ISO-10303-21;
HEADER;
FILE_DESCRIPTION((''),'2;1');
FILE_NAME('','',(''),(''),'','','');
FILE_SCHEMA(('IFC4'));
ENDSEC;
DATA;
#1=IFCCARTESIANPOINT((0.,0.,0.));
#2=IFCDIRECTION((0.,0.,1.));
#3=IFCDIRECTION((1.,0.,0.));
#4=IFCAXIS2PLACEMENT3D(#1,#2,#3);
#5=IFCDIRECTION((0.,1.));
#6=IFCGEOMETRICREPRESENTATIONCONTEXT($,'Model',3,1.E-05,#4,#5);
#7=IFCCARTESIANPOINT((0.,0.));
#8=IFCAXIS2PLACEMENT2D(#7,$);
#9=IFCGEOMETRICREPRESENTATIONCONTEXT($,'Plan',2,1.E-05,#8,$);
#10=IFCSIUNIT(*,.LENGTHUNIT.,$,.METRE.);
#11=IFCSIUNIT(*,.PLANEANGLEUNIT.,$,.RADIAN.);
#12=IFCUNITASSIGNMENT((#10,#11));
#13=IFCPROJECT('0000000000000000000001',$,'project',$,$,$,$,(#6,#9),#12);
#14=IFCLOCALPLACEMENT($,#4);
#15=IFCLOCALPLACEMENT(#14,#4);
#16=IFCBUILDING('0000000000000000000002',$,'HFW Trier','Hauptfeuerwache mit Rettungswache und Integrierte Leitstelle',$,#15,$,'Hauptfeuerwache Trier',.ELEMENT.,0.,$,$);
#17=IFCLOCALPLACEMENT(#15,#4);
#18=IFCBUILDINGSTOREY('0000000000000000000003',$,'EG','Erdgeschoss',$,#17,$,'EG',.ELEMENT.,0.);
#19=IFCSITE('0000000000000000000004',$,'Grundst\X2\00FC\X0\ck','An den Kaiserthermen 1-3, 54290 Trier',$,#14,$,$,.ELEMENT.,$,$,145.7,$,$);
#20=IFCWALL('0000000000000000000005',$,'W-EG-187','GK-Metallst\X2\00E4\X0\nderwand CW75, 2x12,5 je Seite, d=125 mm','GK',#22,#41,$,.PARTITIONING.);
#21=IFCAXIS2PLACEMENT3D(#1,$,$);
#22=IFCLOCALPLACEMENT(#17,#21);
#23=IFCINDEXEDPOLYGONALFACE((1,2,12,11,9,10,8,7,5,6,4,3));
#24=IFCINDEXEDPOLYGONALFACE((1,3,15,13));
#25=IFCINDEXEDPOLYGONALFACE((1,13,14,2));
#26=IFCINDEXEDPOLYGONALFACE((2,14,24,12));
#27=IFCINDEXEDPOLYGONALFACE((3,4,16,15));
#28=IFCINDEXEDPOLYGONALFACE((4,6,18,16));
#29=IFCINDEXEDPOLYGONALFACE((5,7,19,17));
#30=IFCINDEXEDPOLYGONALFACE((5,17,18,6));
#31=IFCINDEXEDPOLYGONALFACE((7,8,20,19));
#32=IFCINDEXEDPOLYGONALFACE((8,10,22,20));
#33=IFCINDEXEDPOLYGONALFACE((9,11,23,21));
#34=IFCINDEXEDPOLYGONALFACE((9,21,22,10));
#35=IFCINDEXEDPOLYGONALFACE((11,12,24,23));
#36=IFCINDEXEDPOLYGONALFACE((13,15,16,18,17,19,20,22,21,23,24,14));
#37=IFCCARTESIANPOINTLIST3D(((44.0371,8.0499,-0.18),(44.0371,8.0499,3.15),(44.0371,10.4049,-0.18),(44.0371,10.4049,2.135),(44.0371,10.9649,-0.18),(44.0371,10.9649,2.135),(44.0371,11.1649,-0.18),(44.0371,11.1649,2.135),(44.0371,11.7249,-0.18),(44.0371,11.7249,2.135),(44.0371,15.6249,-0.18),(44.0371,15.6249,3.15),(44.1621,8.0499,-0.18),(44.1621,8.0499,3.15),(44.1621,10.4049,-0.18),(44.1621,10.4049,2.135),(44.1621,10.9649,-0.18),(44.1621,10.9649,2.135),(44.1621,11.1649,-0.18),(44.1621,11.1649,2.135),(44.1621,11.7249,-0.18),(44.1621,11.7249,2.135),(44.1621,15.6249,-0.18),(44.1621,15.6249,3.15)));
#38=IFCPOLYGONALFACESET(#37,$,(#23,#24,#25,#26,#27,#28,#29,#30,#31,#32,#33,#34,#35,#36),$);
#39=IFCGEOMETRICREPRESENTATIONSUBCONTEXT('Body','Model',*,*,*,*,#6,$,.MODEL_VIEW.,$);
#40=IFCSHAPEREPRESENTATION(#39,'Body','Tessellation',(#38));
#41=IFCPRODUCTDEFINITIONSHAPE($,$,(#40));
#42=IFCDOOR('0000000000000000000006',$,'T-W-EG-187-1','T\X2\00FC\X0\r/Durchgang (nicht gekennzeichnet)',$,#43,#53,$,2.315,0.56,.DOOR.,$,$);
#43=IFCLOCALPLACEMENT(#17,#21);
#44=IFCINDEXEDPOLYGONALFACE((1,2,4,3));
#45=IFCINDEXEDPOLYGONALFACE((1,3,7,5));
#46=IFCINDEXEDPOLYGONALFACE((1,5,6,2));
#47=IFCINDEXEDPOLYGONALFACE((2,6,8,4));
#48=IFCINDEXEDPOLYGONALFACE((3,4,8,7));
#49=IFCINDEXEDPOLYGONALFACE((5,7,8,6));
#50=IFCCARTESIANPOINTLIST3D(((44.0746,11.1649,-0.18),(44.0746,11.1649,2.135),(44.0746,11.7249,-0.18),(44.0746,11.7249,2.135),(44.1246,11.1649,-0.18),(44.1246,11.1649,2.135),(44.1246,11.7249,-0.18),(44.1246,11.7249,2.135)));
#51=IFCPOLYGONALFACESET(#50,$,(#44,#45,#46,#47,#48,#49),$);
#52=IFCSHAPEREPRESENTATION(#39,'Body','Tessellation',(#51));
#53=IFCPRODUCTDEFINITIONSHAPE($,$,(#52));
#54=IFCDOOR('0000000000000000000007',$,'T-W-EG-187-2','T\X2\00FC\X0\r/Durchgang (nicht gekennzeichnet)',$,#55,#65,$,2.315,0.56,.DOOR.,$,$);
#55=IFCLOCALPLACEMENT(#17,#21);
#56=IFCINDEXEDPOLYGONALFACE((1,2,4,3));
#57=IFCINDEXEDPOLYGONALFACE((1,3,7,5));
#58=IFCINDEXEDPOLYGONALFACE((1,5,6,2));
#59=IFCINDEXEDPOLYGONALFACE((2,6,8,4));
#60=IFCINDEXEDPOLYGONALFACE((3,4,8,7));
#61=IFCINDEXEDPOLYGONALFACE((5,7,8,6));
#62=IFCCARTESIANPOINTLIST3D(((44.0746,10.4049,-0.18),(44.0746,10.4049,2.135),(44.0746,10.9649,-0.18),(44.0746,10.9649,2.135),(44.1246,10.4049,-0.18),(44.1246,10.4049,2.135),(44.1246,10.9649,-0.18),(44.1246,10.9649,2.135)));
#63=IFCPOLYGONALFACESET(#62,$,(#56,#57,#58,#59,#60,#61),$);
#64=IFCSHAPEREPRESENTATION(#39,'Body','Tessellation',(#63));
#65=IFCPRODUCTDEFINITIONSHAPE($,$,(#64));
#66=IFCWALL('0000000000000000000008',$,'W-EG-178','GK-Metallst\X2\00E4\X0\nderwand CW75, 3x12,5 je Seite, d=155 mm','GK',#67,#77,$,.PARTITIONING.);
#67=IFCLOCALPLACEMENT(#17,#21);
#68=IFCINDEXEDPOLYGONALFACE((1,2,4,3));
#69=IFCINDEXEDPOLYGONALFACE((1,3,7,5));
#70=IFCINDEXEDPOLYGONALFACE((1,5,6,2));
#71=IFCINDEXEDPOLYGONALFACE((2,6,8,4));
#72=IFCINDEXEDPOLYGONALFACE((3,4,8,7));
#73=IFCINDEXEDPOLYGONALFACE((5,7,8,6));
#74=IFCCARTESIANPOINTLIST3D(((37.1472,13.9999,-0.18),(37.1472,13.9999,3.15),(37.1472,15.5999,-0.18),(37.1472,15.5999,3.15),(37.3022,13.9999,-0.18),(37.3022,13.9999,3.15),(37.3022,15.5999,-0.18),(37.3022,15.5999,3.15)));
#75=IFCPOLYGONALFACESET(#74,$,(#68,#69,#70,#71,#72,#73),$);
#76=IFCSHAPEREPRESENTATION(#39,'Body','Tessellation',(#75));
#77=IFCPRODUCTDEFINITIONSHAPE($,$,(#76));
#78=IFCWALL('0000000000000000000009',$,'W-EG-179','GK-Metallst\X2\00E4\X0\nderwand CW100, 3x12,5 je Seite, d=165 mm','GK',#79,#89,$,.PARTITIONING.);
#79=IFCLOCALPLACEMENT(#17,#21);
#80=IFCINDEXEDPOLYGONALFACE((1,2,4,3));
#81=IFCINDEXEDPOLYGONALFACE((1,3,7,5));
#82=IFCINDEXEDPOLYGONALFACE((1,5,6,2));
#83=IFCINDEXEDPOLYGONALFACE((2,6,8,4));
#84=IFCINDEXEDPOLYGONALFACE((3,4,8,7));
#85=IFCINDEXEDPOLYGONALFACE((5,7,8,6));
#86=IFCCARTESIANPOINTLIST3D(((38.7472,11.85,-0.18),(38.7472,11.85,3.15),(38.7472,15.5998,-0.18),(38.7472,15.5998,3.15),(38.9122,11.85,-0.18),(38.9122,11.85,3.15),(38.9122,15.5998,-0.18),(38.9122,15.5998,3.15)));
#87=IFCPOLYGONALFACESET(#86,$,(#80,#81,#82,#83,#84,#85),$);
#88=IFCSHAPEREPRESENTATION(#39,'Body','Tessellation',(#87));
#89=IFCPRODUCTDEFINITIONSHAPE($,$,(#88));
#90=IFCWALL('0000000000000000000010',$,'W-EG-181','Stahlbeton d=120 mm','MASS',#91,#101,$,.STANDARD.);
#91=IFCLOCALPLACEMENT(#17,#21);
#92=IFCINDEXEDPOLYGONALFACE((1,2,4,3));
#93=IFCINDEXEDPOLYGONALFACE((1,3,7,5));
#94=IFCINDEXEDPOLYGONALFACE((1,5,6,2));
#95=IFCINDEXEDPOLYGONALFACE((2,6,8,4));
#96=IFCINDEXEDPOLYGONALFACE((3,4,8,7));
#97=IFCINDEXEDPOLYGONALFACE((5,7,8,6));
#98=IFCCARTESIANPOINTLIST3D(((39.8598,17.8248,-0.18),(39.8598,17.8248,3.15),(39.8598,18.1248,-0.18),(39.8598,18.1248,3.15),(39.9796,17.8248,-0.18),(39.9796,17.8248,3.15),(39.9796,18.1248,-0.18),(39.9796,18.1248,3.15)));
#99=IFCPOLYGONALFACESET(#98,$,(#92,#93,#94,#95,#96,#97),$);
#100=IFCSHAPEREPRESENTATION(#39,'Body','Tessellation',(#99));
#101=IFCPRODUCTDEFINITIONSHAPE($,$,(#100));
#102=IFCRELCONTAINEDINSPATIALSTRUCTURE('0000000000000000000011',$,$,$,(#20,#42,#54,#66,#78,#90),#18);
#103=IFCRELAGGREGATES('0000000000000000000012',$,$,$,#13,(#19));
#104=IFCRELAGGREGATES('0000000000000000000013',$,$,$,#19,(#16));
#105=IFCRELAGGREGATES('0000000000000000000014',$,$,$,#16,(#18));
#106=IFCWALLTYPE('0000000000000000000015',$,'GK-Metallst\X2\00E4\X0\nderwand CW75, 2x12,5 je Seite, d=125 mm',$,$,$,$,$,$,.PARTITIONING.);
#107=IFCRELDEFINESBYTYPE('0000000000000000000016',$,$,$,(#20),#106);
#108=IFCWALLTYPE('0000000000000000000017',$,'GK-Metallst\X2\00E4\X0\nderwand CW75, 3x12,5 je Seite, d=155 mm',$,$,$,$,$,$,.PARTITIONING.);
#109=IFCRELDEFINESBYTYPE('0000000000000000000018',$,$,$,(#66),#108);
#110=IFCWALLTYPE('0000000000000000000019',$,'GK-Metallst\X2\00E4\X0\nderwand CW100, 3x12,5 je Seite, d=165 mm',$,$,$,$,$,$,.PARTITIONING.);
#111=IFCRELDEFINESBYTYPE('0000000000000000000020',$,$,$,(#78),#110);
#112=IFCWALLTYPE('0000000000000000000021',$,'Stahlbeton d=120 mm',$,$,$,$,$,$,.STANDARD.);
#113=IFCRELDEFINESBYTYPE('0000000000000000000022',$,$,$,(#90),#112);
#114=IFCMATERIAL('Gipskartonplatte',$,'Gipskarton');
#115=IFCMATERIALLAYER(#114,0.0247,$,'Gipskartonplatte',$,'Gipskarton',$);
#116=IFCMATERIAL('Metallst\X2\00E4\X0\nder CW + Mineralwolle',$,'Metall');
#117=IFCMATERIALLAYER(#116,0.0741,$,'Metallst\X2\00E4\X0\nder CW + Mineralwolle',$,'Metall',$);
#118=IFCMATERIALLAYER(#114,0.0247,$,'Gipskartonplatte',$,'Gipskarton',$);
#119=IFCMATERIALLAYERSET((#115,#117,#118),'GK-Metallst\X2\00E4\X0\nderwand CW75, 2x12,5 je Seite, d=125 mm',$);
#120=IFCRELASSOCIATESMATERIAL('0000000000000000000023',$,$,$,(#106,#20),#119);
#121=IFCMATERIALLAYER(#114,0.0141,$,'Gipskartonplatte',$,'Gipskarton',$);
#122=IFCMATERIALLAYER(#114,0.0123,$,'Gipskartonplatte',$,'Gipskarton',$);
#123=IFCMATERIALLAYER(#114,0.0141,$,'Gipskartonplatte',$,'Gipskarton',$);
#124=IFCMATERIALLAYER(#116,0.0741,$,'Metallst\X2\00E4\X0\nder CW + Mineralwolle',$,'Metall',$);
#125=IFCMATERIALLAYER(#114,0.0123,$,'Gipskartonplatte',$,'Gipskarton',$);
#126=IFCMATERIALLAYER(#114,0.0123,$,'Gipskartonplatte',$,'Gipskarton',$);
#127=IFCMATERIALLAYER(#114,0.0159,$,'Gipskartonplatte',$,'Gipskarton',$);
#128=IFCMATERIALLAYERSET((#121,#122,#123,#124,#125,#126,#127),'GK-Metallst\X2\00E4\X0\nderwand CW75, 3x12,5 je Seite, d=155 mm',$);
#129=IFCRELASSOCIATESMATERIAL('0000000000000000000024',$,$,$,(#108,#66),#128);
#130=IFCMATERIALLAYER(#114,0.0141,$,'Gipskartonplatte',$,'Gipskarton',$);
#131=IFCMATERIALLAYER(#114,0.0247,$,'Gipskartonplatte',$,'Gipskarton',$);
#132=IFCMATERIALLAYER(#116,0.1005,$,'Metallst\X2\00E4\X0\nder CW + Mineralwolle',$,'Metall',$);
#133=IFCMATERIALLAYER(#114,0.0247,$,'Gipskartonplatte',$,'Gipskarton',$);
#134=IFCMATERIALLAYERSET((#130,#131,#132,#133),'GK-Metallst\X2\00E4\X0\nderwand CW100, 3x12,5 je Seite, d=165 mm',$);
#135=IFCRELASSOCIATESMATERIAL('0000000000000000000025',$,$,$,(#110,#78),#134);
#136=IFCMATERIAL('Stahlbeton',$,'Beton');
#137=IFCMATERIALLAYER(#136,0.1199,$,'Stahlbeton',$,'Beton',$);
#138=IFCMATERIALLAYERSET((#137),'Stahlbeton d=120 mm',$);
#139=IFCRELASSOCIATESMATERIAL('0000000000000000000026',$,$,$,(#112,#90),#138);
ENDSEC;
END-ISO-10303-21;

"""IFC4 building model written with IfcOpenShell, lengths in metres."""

from ifc_helpers import new_model, si_unit, direction, frame, frame_2d, origin_with_axes, origin_2d, place, context, subcontext, project, spatial, rectangle, extrude, material, layer, layer_set, layer_usage, type_object, element, fill, save


model = new_model("IFC4")

# Units and contexts
model_context = context("Model", 3, precision=1e-05, world=origin_with_axes(), true_north=direction((0.0, 1.0)))
plan_context = context("Plan", 2, precision=1e-05, world=origin_2d())
body_context = subcontext(model_context, "Body", "Model", "MODEL_VIEW")
ifc_project = project(units=[si_unit("LENGTHUNIT", "METRE"), si_unit("PLANEANGLEUNIT", "RADIAN")], contexts=[model_context, plan_context])

# Site, building, storey
site_placement = place(None, origin_with_axes())
site = spatial("IfcSite", under=ifc_project, at=site_placement, Name="Grundstück", Description="An den Kaiserthermen 1-3, 54290 Trier", CompositionType="ELEMENT", RefElevation=145.7)
building_placement = place(site_placement, origin_with_axes())
building = spatial("IfcBuilding", under=site, at=building_placement, Name="HFW Trier", Description="Hauptfeuerwache mit Rettungswache und Integrierte Leitstelle", LongName="Hauptfeuerwache Trier", CompositionType="ELEMENT", ElevationOfRefHeight=0.0)
storey_placement = place(building_placement, origin_with_axes())
storey = spatial("IfcBuildingStorey", under=building, at=storey_placement, Name="EG", Description="Erdgeschoss", LongName="EG", CompositionType="ELEMENT", Elevation=0.0)

# Shared definitions
ifc_material_1 = material(Name="Stahlbeton", Category="Beton")

# Wall, openings, doors
ifc_material_2 = material(Name="Gipskartonplatte", Category="Gipskarton")
ifc_layer_1 = layer(ifc_material_2, 0.0247, Name="Gipskartonplatte", Category="Gipskarton")
ifc_material_3 = material(Name="Metallständer CW + Mineralwolle", Category="Metall")
ifc_layer_2 = layer(ifc_material_3, 0.0741, Name="Metallständer CW + Mineralwolle", Category="Metall")
ifc_layer_3 = layer(ifc_material_2, 0.0247, Name="Gipskartonplatte", Category="Gipskarton")
ifc_layer_set_1 = layer_set([ifc_layer_1, ifc_layer_2, ifc_layer_3], Name="GK-Metallständerwand CW75, 2x12,5 je Seite, d=125 mm")
ifc_layer_usage_1 = layer_usage(ifc_layer_set_1, "AXIS2", "POSITIVE", -0.0625)
wall_type_1 = type_object("IfcWallType", Name="GK-Metallständerwand CW75, 2x12,5 je Seite, d=125 mm", PredefinedType="PARTITIONING", material=ifc_layer_set_1)
wall_1_placement = place(storey_placement, frame((44.0996, 15.6249, -0.18), z_axis=(0.0, 0.0, 1.0), x_axis=(0.0, -1.0, 0.0)))
wall_1 = element("IfcWall", 1, at=wall_1_placement, inside=storey, type_object=wall_type_1, material=ifc_layer_usage_1, Name="W-EG-187", Description="GK-Metallständerwand CW75, 2x12,5 je Seite, d=125 mm", ObjectType="GK", PredefinedType="PARTITIONING", context=body_context, shape_type="SweptSolid", body=[
    extrude(rectangle(XDim=7.575, YDim=0.125, at=frame_2d((3.7875, 0.0))), origin_with_axes(), (0.0, 0.0, 1.0), 3.33),
])
opening_1_placement = place(wall_1_placement, frame((3.9, 0.0, 0.0), z_axis=(0.0, 0.0, 1.0), x_axis=(1.0, 0.0, 0.0)))
opening_1 = element("IfcOpeningElement", 2, at=opening_1_placement, cuts=wall_1, PredefinedType="OPENING", context=body_context, shape_type="SweptSolid", body=[
    extrude(rectangle(XDim=0.56, YDim=0.225, at=frame_2d((0.28, 0.0))), origin_with_axes(), (0.0, 0.0, 1.0), 2.315),
])
opening_2_placement = place(wall_1_placement, frame((4.66, 0.0, 0.0), z_axis=(0.0, 0.0, 1.0), x_axis=(1.0, 0.0, 0.0)))
opening_2 = element("IfcOpeningElement", 3, at=opening_2_placement, cuts=wall_1, PredefinedType="OPENING", context=body_context, shape_type="SweptSolid", body=[
    extrude(rectangle(XDim=0.56, YDim=0.225, at=frame_2d((0.28, 0.0))), origin_with_axes(), (0.0, 0.0, 1.0), 2.315),
])
door_1_placement = place(wall_1_placement, frame((3.9, 0.0, 0.0), z_axis=(0.0, 0.0, 1.0), x_axis=(1.0, 0.0, 0.0)))
door_1 = element("IfcDoor", 4, at=door_1_placement, inside=storey, Name="T-W-EG-187-1", Description="Tür/Durchgang (nicht gekennzeichnet)", OverallHeight=2.315, OverallWidth=0.56, PredefinedType="DOOR", context=body_context, shape_type="SweptSolid", body=[
    extrude(rectangle(XDim=0.56, YDim=0.05, at=frame_2d((0.28, 0.0))), origin_with_axes(), (0.0, 0.0, 1.0), 2.315),
])
fill(opening_1, door_1)
door_2_placement = place(wall_1_placement, frame((4.66, 0.0, 0.0), z_axis=(0.0, 0.0, 1.0), x_axis=(1.0, 0.0, 0.0)))
door_2 = element("IfcDoor", 5, at=door_2_placement, inside=storey, Name="T-W-EG-187-2", Description="Tür/Durchgang (nicht gekennzeichnet)", OverallHeight=2.315, OverallWidth=0.56, PredefinedType="DOOR", context=body_context, shape_type="SweptSolid", body=[
    extrude(rectangle(XDim=0.56, YDim=0.05, at=frame_2d((0.28, 0.0))), origin_with_axes(), (0.0, 0.0, 1.0), 2.315),
])
fill(opening_2, door_2)

# Walls
ifc_layer_4 = layer(ifc_material_2, 0.0141, Name="Gipskartonplatte", Category="Gipskarton")
ifc_layer_5 = layer(ifc_material_2, 0.0123, Name="Gipskartonplatte", Category="Gipskarton")
ifc_layer_6 = layer(ifc_material_2, 0.0141, Name="Gipskartonplatte", Category="Gipskarton")
ifc_layer_7 = layer(ifc_material_3, 0.0741, Name="Metallständer CW + Mineralwolle", Category="Metall")
ifc_layer_8 = layer(ifc_material_2, 0.0123, Name="Gipskartonplatte", Category="Gipskarton")
ifc_layer_9 = layer(ifc_material_2, 0.0123, Name="Gipskartonplatte", Category="Gipskarton")
ifc_layer_10 = layer(ifc_material_2, 0.0159, Name="Gipskartonplatte", Category="Gipskarton")
ifc_layer_set_2 = layer_set([ifc_layer_4, ifc_layer_5, ifc_layer_6, ifc_layer_7, ifc_layer_8, ifc_layer_9, ifc_layer_10], Name="GK-Metallständerwand CW75, 3x12,5 je Seite, d=155 mm")
ifc_layer_usage_2 = layer_usage(ifc_layer_set_2, "AXIS2", "POSITIVE", -0.0775)
wall_type_2 = type_object("IfcWallType", Name="GK-Metallständerwand CW75, 3x12,5 je Seite, d=155 mm", PredefinedType="PARTITIONING", material=ifc_layer_set_2)
wall_2_placement = place(storey_placement, frame((37.2247, 15.5999, -0.18), z_axis=(0.0, 0.0, 1.0), x_axis=(0.0, -1.0, 0.0)))
element("IfcWall", 6, at=wall_2_placement, inside=storey, type_object=wall_type_2, material=ifc_layer_usage_2, Name="W-EG-178", Description="GK-Metallständerwand CW75, 3x12,5 je Seite, d=155 mm", ObjectType="GK", PredefinedType="PARTITIONING", context=body_context, shape_type="SweptSolid", body=[
    extrude(rectangle(XDim=1.6, YDim=0.155, at=frame_2d((0.8, 0.0))), origin_with_axes(), (0.0, 0.0, 1.0), 3.33),
])
ifc_layer_11 = layer(ifc_material_2, 0.0141, Name="Gipskartonplatte", Category="Gipskarton")
ifc_layer_12 = layer(ifc_material_2, 0.0247, Name="Gipskartonplatte", Category="Gipskarton")
ifc_layer_13 = layer(ifc_material_3, 0.1005, Name="Metallständer CW + Mineralwolle", Category="Metall")
ifc_layer_14 = layer(ifc_material_2, 0.0247, Name="Gipskartonplatte", Category="Gipskarton")
ifc_layer_set_3 = layer_set([ifc_layer_11, ifc_layer_12, ifc_layer_13, ifc_layer_14], Name="GK-Metallständerwand CW100, 3x12,5 je Seite, d=165 mm")
ifc_layer_usage_3 = layer_usage(ifc_layer_set_3, "AXIS2", "POSITIVE", -0.0825)
wall_type_3 = type_object("IfcWallType", Name="GK-Metallständerwand CW100, 3x12,5 je Seite, d=165 mm", PredefinedType="PARTITIONING", material=ifc_layer_set_3)
wall_3_placement = place(storey_placement, frame((38.8297, 15.5998, -0.18), z_axis=(0.0, 0.0, 1.0), x_axis=(0.0, -1.0, 0.0)))
element("IfcWall", 7, at=wall_3_placement, inside=storey, type_object=wall_type_3, material=ifc_layer_usage_3, Name="W-EG-179", Description="GK-Metallständerwand CW100, 3x12,5 je Seite, d=165 mm", ObjectType="GK", PredefinedType="PARTITIONING", context=body_context, shape_type="SweptSolid", body=[
    extrude(rectangle(XDim=3.7498, YDim=0.165, at=frame_2d((1.8749, 0.0))), origin_with_axes(), (0.0, 0.0, 1.0), 3.33),
])
ifc_layer_15 = layer(ifc_material_1, 0.1199, Name="Stahlbeton", Category="Beton")
ifc_layer_set_4 = layer_set([ifc_layer_15], Name="Stahlbeton d=120 mm")
ifc_layer_usage_4 = layer_usage(ifc_layer_set_4, "AXIS2", "POSITIVE", -0.0599)
wall_type_4 = type_object("IfcWallType", Name="Stahlbeton d=120 mm", PredefinedType="STANDARD", material=ifc_layer_set_4)
wall_4_placement = place(storey_placement, frame((39.9197, 18.1248, -0.18), z_axis=(0.0, 0.0, 1.0), x_axis=(0.0, -1.0, 0.0)))
element("IfcWall", 8, at=wall_4_placement, inside=storey, type_object=wall_type_4, material=ifc_layer_usage_4, Name="W-EG-181", Description="Stahlbeton d=120 mm", ObjectType="MASS", PredefinedType="STANDARD", context=body_context, shape_type="SweptSolid", body=[
    extrude(rectangle(XDim=0.3, YDim=0.1198, at=frame_2d((0.15, 0.0))), origin_with_axes(), (0.0, 0.0, 1.0), 3.33),
])

save(model, "model.ifc")
